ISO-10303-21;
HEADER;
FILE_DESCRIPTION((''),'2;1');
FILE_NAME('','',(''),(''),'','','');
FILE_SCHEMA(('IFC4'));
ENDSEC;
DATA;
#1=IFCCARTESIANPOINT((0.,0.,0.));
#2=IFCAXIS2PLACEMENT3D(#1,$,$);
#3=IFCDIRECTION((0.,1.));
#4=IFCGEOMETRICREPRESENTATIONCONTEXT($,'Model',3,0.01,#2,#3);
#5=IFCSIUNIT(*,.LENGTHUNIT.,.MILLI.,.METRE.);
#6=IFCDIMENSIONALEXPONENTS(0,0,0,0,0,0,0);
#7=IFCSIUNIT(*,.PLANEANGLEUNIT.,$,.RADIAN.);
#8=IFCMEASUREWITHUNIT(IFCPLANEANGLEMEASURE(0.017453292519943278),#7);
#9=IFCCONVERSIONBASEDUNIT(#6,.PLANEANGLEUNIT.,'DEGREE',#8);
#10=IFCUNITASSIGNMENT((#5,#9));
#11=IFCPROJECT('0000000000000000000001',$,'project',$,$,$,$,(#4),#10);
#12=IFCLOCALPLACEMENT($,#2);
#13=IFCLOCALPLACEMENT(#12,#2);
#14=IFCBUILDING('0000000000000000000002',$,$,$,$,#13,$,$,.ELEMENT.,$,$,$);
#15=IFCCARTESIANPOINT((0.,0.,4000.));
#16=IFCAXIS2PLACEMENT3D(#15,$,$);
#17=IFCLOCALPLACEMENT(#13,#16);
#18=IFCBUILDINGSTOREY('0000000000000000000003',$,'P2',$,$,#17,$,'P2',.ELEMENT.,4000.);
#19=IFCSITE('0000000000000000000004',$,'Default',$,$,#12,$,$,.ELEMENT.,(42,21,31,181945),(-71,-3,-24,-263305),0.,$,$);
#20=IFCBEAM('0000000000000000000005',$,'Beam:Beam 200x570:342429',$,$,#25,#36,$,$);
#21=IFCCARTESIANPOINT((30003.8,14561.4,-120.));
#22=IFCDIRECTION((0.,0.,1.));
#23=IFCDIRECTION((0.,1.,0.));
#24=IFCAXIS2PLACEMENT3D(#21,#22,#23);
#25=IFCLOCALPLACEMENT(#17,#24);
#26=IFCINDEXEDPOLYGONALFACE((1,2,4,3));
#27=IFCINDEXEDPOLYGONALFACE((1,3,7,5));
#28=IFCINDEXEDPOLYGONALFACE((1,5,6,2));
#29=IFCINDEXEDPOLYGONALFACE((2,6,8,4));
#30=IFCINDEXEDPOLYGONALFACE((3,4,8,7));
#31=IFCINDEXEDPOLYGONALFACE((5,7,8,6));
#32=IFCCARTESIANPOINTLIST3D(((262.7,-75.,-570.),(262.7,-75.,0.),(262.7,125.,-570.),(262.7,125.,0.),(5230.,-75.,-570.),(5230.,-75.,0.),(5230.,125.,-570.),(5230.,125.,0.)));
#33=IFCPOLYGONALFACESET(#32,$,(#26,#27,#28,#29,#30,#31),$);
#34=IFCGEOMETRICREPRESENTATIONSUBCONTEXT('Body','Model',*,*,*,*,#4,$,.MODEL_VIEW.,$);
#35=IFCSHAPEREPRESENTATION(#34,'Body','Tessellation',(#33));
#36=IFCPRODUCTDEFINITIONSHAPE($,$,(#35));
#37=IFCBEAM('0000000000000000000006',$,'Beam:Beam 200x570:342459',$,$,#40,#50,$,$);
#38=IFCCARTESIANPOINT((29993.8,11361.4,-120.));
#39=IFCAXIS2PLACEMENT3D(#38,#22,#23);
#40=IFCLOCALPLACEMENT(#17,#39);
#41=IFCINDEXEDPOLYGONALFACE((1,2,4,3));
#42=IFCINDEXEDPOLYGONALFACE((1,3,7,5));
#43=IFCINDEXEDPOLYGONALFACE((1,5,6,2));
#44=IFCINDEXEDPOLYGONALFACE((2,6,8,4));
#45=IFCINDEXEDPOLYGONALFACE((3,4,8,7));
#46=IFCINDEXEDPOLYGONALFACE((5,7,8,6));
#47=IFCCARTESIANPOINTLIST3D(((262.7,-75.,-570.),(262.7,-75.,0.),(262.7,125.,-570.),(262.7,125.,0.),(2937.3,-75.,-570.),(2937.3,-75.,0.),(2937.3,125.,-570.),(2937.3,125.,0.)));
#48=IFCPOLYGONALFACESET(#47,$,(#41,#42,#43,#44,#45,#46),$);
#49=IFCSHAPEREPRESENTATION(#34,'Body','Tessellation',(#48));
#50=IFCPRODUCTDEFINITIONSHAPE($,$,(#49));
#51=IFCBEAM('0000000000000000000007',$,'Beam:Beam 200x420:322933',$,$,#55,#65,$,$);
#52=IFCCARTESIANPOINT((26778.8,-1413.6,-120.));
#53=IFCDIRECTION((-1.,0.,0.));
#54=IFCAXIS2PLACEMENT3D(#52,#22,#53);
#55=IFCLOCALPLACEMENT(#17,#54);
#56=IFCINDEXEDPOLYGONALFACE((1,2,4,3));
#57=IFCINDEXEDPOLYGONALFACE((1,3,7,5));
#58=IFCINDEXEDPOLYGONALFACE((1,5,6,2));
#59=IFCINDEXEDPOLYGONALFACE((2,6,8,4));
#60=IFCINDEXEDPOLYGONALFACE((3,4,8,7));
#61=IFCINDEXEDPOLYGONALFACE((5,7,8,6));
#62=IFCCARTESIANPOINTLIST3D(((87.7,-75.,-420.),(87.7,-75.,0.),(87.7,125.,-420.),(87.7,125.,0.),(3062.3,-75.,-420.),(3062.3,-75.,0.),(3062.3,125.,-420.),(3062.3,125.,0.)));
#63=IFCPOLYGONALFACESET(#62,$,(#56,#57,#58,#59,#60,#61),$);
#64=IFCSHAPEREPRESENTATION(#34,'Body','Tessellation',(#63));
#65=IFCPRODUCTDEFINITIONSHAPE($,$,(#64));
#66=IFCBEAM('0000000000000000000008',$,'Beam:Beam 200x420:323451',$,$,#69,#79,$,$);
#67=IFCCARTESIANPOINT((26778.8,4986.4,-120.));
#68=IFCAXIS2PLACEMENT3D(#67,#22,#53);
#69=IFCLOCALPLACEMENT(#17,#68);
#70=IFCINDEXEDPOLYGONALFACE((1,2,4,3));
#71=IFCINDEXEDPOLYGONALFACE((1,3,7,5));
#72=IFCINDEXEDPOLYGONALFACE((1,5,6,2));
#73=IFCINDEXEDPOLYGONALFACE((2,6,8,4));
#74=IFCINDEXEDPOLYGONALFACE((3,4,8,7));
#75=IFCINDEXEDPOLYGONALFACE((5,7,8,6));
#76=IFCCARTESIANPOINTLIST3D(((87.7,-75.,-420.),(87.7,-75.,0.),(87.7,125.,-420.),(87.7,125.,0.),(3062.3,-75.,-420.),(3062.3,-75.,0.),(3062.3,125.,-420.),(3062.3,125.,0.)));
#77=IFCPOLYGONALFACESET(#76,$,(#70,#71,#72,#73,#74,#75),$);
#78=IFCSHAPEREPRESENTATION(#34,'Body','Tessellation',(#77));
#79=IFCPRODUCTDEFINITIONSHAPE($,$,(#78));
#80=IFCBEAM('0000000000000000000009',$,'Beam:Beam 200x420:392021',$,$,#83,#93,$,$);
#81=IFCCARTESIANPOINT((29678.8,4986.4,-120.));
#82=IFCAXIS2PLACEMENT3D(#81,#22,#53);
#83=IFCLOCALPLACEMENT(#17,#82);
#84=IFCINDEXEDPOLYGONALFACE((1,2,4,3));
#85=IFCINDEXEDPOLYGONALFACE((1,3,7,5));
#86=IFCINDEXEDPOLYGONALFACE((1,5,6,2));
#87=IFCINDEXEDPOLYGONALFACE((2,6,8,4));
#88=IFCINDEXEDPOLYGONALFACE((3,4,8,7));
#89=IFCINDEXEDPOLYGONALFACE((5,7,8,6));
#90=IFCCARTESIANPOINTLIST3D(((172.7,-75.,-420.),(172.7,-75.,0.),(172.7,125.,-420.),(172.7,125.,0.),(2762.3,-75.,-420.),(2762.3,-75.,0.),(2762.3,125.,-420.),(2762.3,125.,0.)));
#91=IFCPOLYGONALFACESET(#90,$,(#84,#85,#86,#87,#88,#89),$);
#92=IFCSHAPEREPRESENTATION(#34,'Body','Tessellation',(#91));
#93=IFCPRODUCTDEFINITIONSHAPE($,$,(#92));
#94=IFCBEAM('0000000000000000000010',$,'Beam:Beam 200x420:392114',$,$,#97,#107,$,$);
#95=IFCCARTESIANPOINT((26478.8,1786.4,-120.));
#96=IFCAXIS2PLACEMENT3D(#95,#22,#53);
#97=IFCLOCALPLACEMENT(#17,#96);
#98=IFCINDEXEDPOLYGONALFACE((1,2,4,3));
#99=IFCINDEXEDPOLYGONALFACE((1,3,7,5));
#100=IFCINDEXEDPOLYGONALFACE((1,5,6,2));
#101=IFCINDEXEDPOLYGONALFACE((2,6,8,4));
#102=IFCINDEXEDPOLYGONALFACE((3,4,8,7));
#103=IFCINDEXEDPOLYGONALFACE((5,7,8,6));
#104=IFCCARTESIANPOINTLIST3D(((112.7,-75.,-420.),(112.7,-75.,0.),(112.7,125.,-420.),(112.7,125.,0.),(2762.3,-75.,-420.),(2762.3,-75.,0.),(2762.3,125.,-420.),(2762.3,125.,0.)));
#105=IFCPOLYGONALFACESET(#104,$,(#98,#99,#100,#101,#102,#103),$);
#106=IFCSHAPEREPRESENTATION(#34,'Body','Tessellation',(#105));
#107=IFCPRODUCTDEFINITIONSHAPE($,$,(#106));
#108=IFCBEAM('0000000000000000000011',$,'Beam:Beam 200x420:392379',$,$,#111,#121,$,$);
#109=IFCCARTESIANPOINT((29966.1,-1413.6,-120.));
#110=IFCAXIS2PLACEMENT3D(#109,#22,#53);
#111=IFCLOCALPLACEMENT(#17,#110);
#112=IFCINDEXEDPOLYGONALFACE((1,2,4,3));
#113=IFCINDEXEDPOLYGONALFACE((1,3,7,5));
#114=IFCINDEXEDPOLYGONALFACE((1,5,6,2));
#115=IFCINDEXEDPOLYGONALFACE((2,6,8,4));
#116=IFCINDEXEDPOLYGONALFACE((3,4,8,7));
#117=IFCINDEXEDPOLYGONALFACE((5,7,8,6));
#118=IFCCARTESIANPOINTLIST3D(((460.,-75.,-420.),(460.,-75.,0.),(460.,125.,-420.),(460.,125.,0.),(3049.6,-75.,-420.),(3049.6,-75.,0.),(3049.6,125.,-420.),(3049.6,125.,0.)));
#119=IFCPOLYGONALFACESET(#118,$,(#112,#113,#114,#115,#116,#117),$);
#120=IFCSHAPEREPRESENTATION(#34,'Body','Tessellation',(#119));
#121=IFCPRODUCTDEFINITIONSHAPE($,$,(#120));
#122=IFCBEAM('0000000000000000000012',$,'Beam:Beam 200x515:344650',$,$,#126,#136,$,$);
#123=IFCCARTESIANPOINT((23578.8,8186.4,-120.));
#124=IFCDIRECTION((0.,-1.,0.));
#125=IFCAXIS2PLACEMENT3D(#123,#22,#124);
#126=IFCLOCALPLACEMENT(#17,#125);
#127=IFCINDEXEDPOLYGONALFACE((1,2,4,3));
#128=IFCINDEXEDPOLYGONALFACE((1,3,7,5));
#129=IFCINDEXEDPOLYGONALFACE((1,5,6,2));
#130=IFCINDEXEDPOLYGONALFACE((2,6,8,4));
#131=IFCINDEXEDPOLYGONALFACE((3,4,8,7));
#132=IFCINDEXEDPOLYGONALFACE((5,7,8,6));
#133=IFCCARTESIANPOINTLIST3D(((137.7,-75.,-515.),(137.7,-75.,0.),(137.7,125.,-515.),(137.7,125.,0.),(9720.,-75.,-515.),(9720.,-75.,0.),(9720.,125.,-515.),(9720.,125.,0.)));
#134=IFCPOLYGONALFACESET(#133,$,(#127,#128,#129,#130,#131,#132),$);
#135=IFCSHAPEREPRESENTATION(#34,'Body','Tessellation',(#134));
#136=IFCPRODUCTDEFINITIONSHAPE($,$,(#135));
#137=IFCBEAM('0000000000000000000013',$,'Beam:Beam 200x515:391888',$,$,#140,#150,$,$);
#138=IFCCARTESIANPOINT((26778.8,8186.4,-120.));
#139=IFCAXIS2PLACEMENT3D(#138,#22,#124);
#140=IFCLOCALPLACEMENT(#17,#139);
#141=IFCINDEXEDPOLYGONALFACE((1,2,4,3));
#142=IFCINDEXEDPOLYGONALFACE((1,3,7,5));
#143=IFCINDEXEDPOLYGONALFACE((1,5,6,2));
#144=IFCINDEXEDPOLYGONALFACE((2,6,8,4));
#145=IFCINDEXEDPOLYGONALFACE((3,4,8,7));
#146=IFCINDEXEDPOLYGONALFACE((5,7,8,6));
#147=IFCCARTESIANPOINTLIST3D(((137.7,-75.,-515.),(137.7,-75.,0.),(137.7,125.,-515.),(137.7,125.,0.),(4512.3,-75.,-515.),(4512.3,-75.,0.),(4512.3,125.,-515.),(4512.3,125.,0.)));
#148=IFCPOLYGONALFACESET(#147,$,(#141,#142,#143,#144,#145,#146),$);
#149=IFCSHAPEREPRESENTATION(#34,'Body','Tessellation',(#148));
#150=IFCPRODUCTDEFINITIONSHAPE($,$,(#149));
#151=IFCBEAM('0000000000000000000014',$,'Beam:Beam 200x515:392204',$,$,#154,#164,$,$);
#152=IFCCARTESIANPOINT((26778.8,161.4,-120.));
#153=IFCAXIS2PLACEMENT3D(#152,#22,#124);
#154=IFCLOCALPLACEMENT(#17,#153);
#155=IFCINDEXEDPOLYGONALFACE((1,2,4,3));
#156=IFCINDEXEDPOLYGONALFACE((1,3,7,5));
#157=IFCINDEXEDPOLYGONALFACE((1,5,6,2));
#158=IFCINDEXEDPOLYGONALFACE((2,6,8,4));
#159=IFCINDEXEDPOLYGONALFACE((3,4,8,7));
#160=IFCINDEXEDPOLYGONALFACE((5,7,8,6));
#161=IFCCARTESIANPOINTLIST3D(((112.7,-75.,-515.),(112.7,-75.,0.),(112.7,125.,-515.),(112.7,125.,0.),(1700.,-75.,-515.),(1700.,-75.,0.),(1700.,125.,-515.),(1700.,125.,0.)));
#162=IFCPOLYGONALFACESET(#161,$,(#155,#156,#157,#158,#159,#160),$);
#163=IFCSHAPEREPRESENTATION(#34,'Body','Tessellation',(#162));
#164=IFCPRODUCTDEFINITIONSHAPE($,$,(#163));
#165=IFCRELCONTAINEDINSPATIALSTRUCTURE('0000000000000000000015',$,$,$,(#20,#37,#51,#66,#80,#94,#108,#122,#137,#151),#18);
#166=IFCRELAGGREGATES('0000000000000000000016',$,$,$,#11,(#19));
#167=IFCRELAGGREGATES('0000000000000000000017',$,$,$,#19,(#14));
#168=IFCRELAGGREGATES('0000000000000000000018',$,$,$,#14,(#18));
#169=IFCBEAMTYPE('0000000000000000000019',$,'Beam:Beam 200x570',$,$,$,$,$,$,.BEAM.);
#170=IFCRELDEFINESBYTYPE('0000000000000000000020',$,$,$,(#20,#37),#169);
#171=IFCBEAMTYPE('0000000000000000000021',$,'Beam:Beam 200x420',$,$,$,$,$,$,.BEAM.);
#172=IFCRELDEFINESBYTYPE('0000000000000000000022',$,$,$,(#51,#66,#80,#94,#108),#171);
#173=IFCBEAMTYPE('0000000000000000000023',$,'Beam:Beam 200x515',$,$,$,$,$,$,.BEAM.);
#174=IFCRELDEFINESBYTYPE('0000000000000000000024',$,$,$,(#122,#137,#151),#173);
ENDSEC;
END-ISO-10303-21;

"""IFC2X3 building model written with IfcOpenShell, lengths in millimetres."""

from ifc_helpers import new_model, entity, si_unit, converted_unit, direction, frame, frame_2d, origin, origin_2d_with_axis, place, context, subcontext, project, spatial, rectangle, extrude, type_object, element, save


model = new_model("IFC2X3")

# Units and contexts
model_context = context("Model", 3, precision=0.01, world=origin(), true_north=direction((0.0, 1.0)))
body_context = subcontext(model_context, "Body", "Model", "MODEL_VIEW")
ifc_project = project(units=[si_unit("LENGTHUNIT", "METRE", prefix="MILLI"), converted_unit("PLANEANGLEUNIT", "DEGREE", entity("IfcPlaneAngleMeasure", 0.017453292519943278), si_unit("PLANEANGLEUNIT", "RADIAN"), dimensions=[0, 0, 0, 0, 0, 0, 0])], contexts=[model_context])

# Site, building, storey
site_placement = place(None, origin())
site = spatial("IfcSite", under=ifc_project, at=site_placement, Name="Default", CompositionType="ELEMENT", RefLatitude=(42, 21, 31, 181945), RefLongitude=(-71, -3, -24, -263305), RefElevation=0.0)
building_placement = place(site_placement, origin())
building = spatial("IfcBuilding", under=site, at=building_placement, CompositionType="ELEMENT")
storey_placement = place(building_placement, frame((0.0, 0.0, 4000.0)))
storey = spatial("IfcBuildingStorey", under=building, at=storey_placement, Name="P2", LongName="P2", CompositionType="ELEMENT", Elevation=4000.0)

# Beams
beam_type_1 = type_object("IfcBeamType", Name="Beam:Beam 200x570", PredefinedType="BEAM")
beam_1_placement = place(storey_placement, frame((30003.8, 14561.4, -120.0), z_axis=(0.0, 0.0, 1.0), x_axis=(0.0, 1.0, 0.0)))
element("IfcBeam", 1, at=beam_1_placement, inside=storey, type_object=beam_type_1, Name="Beam:Beam 200x570:342429", context=body_context, shape_type="SweptSolid", body=[
    extrude(rectangle(XDim=570.0, YDim=200.0, at=frame_2d((0.0, 0.0), x_axis=(1.0, 0.0))), frame((262.7, 25.0, -285.0), z_axis=(1.0, 0.0, 0.0), x_axis=(0.0, 0.0, -1.0)), (0.0, 0.0, 1.0), 4967.3),
])
beam_2_placement = place(storey_placement, frame((29993.8, 11361.4, -120.0), z_axis=(0.0, 0.0, 1.0), x_axis=(0.0, 1.0, 0.0)))
element("IfcBeam", 2, at=beam_2_placement, inside=storey, type_object=beam_type_1, Name="Beam:Beam 200x570:342459", context=body_context, shape_type="SweptSolid", body=[
    extrude(rectangle(XDim=570.0, YDim=200.0, at=frame_2d((0.0, 0.0), x_axis=(1.0, 0.0))), frame((262.7, 25.0, -285.0), z_axis=(1.0, 0.0, 0.0), x_axis=(0.0, 0.0, -1.0)), (0.0, 0.0, 1.0), 2674.6),
])
beam_type_2 = type_object("IfcBeamType", Name="Beam:Beam 200x420", PredefinedType="BEAM")
beam_3_placement = place(storey_placement, frame((26778.8, -1413.6, -120.0), z_axis=(0.0, 0.0, 1.0), x_axis=(-1.0, 0.0, 0.0)))
element("IfcBeam", 3, at=beam_3_placement, inside=storey, type_object=beam_type_2, Name="Beam:Beam 200x420:322933", context=body_context, shape_type="SweptSolid", body=[
    extrude(rectangle(XDim=420.0, YDim=200.0, at=origin_2d_with_axis()), frame((87.7, 25.0, -210.0), z_axis=(1.0, 0.0, 0.0), x_axis=(0.0, 0.0, -1.0)), (0.0, 0.0, 1.0), 2974.6),
])
beam_4_placement = place(storey_placement, frame((26778.8, 4986.4, -120.0), z_axis=(0.0, 0.0, 1.0), x_axis=(-1.0, 0.0, 0.0)))
element("IfcBeam", 4, at=beam_4_placement, inside=storey, type_object=beam_type_2, Name="Beam:Beam 200x420:323451", context=body_context, shape_type="SweptSolid", body=[
    extrude(rectangle(XDim=420.0, YDim=200.0, at=frame_2d((0.0, 0.0), x_axis=(1.0, 0.0))), frame((87.7, 25.0, -210.0), z_axis=(1.0, 0.0, 0.0), x_axis=(0.0, 0.0, -1.0)), (0.0, 0.0, 1.0), 2974.6),
])
beam_5_placement = place(storey_placement, frame((29678.8, 4986.4, -120.0), z_axis=(0.0, 0.0, 1.0), x_axis=(-1.0, 0.0, 0.0)))
element("IfcBeam", 5, at=beam_5_placement, inside=storey, type_object=beam_type_2, Name="Beam:Beam 200x420:392021", context=body_context, shape_type="SweptSolid", body=[
    extrude(rectangle(XDim=420.0, YDim=200.0, at=frame_2d((0.0, 0.0), x_axis=(1.0, 0.0))), frame((172.7, 25.0, -210.0), z_axis=(1.0, 0.0, 0.0), x_axis=(0.0, 0.0, -1.0)), (0.0, 0.0, 1.0), 2589.6),
])
beam_6_placement = place(storey_placement, frame((26478.8, 1786.4, -120.0), z_axis=(0.0, 0.0, 1.0), x_axis=(-1.0, 0.0, 0.0)))
element("IfcBeam", 6, at=beam_6_placement, inside=storey, type_object=beam_type_2, Name="Beam:Beam 200x420:392114", context=body_context, shape_type="SweptSolid", body=[
    extrude(rectangle(XDim=420.0, YDim=200.0, at=origin_2d_with_axis()), frame((112.7, 25.0, -210.0), z_axis=(1.0, 0.0, 0.0), x_axis=(0.0, 0.0, -1.0)), (0.0, 0.0, 1.0), 2649.6),
])
beam_7_placement = place(storey_placement, frame((29966.1, -1413.6, -120.0), z_axis=(0.0, 0.0, 1.0), x_axis=(-1.0, 0.0, 0.0)))
element("IfcBeam", 7, at=beam_7_placement, inside=storey, type_object=beam_type_2, Name="Beam:Beam 200x420:392379", context=body_context, shape_type="SweptSolid", body=[
    extrude(rectangle(XDim=420.0, YDim=200.0, at=frame_2d((0.0, 0.0), x_axis=(1.0, 0.0))), frame((460.0, 25.0, -210.0), z_axis=(1.0, 0.0, 0.0), x_axis=(0.0, 0.0, -1.0)), (0.0, 0.0, 1.0), 2589.6),
])
beam_type_3 = type_object("IfcBeamType", Name="Beam:Beam 200x515", PredefinedType="BEAM")
beam_8_placement = place(storey_placement, frame((23578.8, 8186.4, -120.0), z_axis=(0.0, 0.0, 1.0), x_axis=(0.0, -1.0, 0.0)))
element("IfcBeam", 8, at=beam_8_placement, inside=storey, type_object=beam_type_3, Name="Beam:Beam 200x515:344650", context=body_context, shape_type="SweptSolid", body=[
    extrude(rectangle(XDim=515.0, YDim=200.0, at=frame_2d((0.0, 0.0), x_axis=(1.0, 0.0))), frame((137.7, 25.0, -257.5), z_axis=(1.0, 0.0, 0.0), x_axis=(0.0, 0.0, -1.0)), (0.0, 0.0, 1.0), 9582.3),
])
beam_9_placement = place(storey_placement, frame((26778.8, 8186.4, -120.0), z_axis=(0.0, 0.0, 1.0), x_axis=(0.0, -1.0, 0.0)))
element("IfcBeam", 9, at=beam_9_placement, inside=storey, type_object=beam_type_3, Name="Beam:Beam 200x515:391888", context=body_context, shape_type="SweptSolid", body=[
    extrude(rectangle(XDim=515.0, YDim=200.0, at=frame_2d((0.0, 0.0), x_axis=(1.0, 0.0))), frame((137.7, 25.0, -257.5), z_axis=(1.0, 0.0, 0.0), x_axis=(0.0, 0.0, -1.0)), (0.0, 0.0, 1.0), 4374.6),
])
beam_10_placement = place(storey_placement, frame((26778.8, 161.4, -120.0), z_axis=(0.0, 0.0, 1.0), x_axis=(0.0, -1.0, 0.0)))
element("IfcBeam", 10, at=beam_10_placement, inside=storey, type_object=beam_type_3, Name="Beam:Beam 200x515:392204", context=body_context, shape_type="SweptSolid", body=[
    extrude(rectangle(XDim=515.0, YDim=200.0, at=origin_2d_with_axis()), frame((112.7, 25.0, -257.5), z_axis=(1.0, 0.0, 0.0), x_axis=(0.0, 0.0, -1.0)), (0.0, 0.0, 1.0), 1587.3),
])

save(model, "model.ifc")
